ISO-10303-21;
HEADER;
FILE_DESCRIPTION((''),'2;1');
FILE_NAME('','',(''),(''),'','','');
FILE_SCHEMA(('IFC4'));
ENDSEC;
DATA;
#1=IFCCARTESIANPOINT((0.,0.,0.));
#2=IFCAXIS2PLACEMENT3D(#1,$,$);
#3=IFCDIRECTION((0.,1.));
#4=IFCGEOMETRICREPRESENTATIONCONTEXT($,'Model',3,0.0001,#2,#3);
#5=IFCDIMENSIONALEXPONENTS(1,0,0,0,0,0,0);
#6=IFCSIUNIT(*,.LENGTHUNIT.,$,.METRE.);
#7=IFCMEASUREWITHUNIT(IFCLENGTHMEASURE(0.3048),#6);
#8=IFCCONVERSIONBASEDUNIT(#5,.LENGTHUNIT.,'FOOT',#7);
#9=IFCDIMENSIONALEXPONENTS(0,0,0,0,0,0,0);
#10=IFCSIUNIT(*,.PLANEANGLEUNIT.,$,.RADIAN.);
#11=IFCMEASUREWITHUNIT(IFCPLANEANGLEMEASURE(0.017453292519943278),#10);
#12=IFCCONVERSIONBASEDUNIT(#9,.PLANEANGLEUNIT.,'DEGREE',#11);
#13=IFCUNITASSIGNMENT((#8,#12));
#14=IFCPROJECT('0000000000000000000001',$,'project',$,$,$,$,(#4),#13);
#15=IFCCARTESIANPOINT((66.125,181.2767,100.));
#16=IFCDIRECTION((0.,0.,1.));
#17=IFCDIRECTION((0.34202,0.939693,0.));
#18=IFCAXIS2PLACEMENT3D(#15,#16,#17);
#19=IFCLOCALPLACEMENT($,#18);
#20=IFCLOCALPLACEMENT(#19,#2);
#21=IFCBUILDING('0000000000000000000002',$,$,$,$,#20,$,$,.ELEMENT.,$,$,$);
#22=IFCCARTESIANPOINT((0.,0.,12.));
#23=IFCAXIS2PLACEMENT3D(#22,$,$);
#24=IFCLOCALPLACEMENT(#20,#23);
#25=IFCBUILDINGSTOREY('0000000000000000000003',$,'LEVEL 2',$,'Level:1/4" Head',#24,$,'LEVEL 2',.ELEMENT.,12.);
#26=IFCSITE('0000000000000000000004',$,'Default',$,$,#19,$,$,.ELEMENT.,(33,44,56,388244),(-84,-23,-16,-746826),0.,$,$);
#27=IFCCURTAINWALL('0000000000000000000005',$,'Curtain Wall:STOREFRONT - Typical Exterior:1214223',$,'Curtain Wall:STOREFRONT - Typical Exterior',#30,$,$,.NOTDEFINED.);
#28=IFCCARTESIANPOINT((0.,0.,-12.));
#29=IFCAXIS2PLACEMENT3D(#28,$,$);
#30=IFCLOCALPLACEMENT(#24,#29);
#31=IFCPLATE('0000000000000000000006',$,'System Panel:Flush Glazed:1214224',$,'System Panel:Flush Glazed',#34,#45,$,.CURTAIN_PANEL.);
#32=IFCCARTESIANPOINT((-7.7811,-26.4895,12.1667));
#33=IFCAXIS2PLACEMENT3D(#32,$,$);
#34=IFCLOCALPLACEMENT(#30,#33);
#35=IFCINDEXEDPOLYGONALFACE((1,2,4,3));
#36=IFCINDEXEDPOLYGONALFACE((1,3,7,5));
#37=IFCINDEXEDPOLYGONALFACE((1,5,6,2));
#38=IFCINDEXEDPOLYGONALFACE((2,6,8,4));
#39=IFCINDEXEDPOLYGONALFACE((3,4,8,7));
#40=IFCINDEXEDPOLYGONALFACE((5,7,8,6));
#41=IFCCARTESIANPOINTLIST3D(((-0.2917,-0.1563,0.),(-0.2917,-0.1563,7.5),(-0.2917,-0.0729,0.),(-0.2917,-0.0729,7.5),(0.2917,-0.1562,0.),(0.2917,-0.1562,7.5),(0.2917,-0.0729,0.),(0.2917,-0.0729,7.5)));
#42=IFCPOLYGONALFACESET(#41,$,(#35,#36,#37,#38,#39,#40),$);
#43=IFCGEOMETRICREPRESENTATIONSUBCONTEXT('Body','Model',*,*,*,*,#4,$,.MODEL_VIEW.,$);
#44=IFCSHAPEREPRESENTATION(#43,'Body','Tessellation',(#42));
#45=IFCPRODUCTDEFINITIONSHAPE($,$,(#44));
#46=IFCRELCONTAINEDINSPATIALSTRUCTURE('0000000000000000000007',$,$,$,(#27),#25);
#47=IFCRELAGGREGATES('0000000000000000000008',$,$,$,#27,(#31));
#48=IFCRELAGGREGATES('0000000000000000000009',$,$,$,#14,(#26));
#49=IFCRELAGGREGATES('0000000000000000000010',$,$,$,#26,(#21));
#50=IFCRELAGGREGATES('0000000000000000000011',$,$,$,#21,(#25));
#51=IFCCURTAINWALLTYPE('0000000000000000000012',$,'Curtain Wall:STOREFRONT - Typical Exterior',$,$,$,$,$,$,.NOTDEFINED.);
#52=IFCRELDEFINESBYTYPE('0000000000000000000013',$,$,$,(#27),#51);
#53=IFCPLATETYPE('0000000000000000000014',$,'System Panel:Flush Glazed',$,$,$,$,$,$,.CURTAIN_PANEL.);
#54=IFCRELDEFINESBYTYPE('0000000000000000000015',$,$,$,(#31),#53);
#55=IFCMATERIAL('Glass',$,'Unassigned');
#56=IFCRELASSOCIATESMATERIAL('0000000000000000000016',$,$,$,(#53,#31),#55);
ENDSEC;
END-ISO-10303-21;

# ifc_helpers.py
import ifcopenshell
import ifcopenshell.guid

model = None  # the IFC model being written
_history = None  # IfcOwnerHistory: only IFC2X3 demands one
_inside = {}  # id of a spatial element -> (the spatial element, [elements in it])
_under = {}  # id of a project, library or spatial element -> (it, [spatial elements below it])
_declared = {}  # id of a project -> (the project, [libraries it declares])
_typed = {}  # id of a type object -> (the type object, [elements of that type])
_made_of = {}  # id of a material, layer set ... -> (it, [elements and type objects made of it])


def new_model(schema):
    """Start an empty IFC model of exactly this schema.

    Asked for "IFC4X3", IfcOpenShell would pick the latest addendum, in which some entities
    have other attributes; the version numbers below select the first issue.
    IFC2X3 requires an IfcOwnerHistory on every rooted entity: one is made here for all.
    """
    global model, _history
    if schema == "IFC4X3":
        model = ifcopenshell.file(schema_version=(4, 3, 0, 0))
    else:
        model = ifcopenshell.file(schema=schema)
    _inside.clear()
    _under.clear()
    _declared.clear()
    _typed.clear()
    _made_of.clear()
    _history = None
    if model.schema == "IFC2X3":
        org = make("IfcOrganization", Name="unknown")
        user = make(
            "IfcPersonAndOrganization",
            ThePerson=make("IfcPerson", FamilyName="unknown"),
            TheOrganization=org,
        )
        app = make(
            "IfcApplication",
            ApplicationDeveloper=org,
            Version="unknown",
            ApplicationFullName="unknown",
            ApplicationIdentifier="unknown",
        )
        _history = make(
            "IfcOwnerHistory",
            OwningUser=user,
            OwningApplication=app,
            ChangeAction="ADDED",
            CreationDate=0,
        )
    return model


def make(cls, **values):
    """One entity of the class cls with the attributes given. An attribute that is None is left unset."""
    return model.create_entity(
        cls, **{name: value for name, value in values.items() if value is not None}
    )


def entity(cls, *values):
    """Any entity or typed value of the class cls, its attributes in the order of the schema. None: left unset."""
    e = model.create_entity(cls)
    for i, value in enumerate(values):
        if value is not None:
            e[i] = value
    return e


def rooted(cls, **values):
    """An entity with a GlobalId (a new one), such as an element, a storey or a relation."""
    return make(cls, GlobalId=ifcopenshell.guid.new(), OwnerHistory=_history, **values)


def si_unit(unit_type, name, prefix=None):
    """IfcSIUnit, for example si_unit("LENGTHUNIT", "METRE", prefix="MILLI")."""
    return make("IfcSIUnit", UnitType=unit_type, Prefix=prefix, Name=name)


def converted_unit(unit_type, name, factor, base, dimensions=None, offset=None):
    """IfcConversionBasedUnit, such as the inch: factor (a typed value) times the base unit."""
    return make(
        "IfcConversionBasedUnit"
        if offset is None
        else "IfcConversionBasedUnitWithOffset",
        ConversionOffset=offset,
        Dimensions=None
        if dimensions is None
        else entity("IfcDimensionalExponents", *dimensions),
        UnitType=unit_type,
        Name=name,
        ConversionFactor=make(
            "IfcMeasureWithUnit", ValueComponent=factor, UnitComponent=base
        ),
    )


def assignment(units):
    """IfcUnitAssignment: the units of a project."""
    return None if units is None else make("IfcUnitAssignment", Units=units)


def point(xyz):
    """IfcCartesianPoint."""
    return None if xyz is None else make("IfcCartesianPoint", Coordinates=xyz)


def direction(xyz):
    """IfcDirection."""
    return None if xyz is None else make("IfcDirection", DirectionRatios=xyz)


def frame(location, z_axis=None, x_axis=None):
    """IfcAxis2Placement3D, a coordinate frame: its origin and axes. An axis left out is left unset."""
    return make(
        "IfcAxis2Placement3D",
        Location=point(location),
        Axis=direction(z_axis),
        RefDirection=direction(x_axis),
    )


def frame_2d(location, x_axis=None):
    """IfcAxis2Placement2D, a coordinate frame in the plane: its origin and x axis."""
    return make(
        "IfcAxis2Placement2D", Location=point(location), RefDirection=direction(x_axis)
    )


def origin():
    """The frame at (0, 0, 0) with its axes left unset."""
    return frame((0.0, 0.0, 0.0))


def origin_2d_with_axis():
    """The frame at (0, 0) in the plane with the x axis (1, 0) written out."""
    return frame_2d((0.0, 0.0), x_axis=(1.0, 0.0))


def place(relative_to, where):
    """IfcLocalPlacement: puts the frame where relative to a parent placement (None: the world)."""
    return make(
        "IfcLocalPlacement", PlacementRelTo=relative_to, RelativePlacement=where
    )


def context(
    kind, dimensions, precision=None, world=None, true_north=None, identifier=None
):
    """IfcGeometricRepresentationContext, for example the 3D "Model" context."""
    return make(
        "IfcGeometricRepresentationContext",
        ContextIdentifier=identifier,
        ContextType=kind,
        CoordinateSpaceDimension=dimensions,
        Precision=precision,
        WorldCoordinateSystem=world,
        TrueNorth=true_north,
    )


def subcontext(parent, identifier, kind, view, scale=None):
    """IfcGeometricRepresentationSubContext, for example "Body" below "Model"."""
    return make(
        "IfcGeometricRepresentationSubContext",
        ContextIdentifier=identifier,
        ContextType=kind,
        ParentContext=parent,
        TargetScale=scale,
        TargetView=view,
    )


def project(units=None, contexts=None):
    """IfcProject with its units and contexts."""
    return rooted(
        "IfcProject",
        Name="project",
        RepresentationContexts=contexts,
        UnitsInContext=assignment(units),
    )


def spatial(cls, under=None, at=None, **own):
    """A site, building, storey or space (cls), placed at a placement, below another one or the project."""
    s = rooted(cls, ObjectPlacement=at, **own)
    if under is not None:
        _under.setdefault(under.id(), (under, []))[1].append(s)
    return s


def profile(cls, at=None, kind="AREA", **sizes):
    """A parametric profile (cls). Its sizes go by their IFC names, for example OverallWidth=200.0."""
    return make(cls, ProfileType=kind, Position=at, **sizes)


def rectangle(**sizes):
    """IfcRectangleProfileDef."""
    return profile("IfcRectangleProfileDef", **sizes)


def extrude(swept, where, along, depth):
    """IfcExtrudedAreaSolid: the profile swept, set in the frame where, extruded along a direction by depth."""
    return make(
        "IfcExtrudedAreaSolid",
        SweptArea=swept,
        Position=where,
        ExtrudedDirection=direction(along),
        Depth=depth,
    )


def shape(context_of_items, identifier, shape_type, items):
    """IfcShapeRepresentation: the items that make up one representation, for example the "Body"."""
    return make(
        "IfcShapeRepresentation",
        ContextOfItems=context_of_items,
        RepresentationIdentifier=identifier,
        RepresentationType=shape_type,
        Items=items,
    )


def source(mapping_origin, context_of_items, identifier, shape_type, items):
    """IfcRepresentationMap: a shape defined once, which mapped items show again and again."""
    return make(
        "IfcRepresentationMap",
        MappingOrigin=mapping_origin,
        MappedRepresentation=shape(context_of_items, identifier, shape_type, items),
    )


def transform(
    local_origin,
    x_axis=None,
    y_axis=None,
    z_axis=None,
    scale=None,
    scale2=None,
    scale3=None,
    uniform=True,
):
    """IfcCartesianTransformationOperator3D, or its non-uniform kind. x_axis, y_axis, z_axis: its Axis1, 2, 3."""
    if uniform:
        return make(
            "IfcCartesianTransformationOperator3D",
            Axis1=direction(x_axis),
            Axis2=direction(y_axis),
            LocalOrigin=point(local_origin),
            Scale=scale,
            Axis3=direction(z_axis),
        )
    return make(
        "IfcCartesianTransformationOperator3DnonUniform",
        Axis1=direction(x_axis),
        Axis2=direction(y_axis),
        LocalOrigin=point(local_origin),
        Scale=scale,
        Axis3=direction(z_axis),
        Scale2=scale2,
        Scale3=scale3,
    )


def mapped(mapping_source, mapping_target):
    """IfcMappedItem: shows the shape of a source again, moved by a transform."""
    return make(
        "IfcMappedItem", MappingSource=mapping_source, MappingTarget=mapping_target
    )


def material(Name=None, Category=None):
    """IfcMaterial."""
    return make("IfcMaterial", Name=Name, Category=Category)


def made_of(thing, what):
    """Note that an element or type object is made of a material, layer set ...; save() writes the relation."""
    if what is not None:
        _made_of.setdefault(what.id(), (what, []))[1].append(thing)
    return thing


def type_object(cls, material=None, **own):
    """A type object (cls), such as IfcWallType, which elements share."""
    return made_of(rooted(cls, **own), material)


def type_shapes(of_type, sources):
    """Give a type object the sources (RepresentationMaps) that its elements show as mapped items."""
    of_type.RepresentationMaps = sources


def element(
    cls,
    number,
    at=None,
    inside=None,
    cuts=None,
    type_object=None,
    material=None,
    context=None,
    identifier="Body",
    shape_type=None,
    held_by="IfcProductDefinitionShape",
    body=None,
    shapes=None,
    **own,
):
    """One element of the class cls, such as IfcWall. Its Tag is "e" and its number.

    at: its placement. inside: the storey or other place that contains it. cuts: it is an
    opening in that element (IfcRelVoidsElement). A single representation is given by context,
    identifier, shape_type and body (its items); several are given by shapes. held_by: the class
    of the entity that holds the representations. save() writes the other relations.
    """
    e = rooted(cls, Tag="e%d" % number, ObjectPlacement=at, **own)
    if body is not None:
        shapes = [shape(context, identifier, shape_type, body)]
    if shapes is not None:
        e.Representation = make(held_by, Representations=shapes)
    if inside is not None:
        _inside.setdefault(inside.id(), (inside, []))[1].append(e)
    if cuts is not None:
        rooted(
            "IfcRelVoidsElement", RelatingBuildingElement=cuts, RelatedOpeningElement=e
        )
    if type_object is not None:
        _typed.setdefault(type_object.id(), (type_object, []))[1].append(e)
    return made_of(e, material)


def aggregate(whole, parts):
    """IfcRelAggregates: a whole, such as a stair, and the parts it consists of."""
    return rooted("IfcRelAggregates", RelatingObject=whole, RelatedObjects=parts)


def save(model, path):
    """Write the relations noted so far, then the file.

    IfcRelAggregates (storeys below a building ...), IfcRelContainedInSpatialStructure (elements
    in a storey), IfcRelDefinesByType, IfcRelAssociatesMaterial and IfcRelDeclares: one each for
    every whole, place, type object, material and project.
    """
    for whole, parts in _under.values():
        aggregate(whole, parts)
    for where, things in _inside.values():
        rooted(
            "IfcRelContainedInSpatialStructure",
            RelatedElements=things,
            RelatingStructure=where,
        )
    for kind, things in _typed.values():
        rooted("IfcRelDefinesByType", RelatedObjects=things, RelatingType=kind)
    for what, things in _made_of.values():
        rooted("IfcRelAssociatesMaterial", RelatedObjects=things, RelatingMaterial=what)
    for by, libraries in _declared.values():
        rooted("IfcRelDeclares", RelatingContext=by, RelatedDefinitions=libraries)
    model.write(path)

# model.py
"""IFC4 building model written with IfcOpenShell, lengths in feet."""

from ifc_helpers import new_model, entity, si_unit, converted_unit, direction, frame, origin, origin_2d_with_axis, place, context, subcontext, project, spatial, rectangle, extrude, source, transform, mapped, material, type_object, type_shapes, element, aggregate, save


model = new_model("IFC4")

# Units and contexts
model_context = context("Model", 3, precision=0.0001, world=origin(), true_north=direction((0.0, 1.0)))
body_context = subcontext(model_context, "Body", "Model", "MODEL_VIEW")
ifc_project = project(units=[converted_unit("LENGTHUNIT", "FOOT", entity("IfcLengthMeasure", 0.3048), si_unit("LENGTHUNIT", "METRE"), dimensions=[1, 0, 0, 0, 0, 0, 0]), converted_unit("PLANEANGLEUNIT", "DEGREE", entity("IfcPlaneAngleMeasure", 0.017453292519943278), si_unit("PLANEANGLEUNIT", "RADIAN"), dimensions=[0, 0, 0, 0, 0, 0, 0])], contexts=[model_context])

# Site, building, storey
site_placement = place(None, frame((66.125, 181.2767, 100.0), z_axis=(0.0, 0.0, 1.0), x_axis=(0.34202, 0.939693, 0.0)))
site = spatial("IfcSite", under=ifc_project, at=site_placement, Name="Default", CompositionType="ELEMENT", RefLatitude=(33, 44, 56, 388244), RefLongitude=(-84, -23, -16, -746826), RefElevation=0.0)
building_placement = place(site_placement, origin())
building = spatial("IfcBuilding", under=site, at=building_placement, CompositionType="ELEMENT")
storey_placement = place(building_placement, frame((0.0, 0.0, 12.0)))
storey = spatial("IfcBuildingStorey", under=building, at=storey_placement, Name="LEVEL 2", ObjectType="Level:1/4\" Head", LongName="LEVEL 2", CompositionType="ELEMENT", Elevation=12.0)

# Shared definitions
curtain_wall_type = type_object("IfcCurtainWallType", Name="Curtain Wall:STOREFRONT - Typical Exterior", PredefinedType="NOTDEFINED")

# Curtain wall
curtain_wall_1_placement = place(storey_placement, frame((0.0, 0.0, -12.0)))
curtain_wall_1 = element("IfcCurtainWall", 1, at=curtain_wall_1_placement, inside=storey, type_object=curtain_wall_type, Name="Curtain Wall:STOREFRONT - Typical Exterior:1214223", ObjectType="Curtain Wall:STOREFRONT - Typical Exterior", PredefinedType="NOTDEFINED")

# Plate
ifc_material_1 = material(Name="Glass", Category="Unassigned")
plate_type = type_object("IfcPlateType", Name="System Panel:Flush Glazed", PredefinedType="CURTAIN_PANEL", material=ifc_material_1)
shared_shape_1 = source(origin(), body_context, "Body", "SweptSolid", [
    extrude(rectangle(XDim=0.0833, YDim=0.5833, at=origin_2d_with_axis()), frame((0.0, -0.1146, 0.0), z_axis=(0.0, 0.0, 1.0), x_axis=(0.0, 1.0, 0.0)), (0.0, 0.0, 1.0), 7.5),
])
type_shapes(plate_type, [shared_shape_1])
plate_placement = place(curtain_wall_1_placement, frame((-7.7811, -26.4895, 12.1667)))
plate = element("IfcPlate", 2, at=plate_placement, type_object=plate_type, material=ifc_material_1, Name="System Panel:Flush Glazed:1214224", ObjectType="System Panel:Flush Glazed", PredefinedType="CURTAIN_PANEL", context=body_context, shape_type="MappedRepresentation", body=[
    mapped(shared_shape_1, transform((0.0, 0.0, 0.0), scale=1.0)),
])

aggregate(curtain_wall_1, [plate])

save(model, "model.ifc")
